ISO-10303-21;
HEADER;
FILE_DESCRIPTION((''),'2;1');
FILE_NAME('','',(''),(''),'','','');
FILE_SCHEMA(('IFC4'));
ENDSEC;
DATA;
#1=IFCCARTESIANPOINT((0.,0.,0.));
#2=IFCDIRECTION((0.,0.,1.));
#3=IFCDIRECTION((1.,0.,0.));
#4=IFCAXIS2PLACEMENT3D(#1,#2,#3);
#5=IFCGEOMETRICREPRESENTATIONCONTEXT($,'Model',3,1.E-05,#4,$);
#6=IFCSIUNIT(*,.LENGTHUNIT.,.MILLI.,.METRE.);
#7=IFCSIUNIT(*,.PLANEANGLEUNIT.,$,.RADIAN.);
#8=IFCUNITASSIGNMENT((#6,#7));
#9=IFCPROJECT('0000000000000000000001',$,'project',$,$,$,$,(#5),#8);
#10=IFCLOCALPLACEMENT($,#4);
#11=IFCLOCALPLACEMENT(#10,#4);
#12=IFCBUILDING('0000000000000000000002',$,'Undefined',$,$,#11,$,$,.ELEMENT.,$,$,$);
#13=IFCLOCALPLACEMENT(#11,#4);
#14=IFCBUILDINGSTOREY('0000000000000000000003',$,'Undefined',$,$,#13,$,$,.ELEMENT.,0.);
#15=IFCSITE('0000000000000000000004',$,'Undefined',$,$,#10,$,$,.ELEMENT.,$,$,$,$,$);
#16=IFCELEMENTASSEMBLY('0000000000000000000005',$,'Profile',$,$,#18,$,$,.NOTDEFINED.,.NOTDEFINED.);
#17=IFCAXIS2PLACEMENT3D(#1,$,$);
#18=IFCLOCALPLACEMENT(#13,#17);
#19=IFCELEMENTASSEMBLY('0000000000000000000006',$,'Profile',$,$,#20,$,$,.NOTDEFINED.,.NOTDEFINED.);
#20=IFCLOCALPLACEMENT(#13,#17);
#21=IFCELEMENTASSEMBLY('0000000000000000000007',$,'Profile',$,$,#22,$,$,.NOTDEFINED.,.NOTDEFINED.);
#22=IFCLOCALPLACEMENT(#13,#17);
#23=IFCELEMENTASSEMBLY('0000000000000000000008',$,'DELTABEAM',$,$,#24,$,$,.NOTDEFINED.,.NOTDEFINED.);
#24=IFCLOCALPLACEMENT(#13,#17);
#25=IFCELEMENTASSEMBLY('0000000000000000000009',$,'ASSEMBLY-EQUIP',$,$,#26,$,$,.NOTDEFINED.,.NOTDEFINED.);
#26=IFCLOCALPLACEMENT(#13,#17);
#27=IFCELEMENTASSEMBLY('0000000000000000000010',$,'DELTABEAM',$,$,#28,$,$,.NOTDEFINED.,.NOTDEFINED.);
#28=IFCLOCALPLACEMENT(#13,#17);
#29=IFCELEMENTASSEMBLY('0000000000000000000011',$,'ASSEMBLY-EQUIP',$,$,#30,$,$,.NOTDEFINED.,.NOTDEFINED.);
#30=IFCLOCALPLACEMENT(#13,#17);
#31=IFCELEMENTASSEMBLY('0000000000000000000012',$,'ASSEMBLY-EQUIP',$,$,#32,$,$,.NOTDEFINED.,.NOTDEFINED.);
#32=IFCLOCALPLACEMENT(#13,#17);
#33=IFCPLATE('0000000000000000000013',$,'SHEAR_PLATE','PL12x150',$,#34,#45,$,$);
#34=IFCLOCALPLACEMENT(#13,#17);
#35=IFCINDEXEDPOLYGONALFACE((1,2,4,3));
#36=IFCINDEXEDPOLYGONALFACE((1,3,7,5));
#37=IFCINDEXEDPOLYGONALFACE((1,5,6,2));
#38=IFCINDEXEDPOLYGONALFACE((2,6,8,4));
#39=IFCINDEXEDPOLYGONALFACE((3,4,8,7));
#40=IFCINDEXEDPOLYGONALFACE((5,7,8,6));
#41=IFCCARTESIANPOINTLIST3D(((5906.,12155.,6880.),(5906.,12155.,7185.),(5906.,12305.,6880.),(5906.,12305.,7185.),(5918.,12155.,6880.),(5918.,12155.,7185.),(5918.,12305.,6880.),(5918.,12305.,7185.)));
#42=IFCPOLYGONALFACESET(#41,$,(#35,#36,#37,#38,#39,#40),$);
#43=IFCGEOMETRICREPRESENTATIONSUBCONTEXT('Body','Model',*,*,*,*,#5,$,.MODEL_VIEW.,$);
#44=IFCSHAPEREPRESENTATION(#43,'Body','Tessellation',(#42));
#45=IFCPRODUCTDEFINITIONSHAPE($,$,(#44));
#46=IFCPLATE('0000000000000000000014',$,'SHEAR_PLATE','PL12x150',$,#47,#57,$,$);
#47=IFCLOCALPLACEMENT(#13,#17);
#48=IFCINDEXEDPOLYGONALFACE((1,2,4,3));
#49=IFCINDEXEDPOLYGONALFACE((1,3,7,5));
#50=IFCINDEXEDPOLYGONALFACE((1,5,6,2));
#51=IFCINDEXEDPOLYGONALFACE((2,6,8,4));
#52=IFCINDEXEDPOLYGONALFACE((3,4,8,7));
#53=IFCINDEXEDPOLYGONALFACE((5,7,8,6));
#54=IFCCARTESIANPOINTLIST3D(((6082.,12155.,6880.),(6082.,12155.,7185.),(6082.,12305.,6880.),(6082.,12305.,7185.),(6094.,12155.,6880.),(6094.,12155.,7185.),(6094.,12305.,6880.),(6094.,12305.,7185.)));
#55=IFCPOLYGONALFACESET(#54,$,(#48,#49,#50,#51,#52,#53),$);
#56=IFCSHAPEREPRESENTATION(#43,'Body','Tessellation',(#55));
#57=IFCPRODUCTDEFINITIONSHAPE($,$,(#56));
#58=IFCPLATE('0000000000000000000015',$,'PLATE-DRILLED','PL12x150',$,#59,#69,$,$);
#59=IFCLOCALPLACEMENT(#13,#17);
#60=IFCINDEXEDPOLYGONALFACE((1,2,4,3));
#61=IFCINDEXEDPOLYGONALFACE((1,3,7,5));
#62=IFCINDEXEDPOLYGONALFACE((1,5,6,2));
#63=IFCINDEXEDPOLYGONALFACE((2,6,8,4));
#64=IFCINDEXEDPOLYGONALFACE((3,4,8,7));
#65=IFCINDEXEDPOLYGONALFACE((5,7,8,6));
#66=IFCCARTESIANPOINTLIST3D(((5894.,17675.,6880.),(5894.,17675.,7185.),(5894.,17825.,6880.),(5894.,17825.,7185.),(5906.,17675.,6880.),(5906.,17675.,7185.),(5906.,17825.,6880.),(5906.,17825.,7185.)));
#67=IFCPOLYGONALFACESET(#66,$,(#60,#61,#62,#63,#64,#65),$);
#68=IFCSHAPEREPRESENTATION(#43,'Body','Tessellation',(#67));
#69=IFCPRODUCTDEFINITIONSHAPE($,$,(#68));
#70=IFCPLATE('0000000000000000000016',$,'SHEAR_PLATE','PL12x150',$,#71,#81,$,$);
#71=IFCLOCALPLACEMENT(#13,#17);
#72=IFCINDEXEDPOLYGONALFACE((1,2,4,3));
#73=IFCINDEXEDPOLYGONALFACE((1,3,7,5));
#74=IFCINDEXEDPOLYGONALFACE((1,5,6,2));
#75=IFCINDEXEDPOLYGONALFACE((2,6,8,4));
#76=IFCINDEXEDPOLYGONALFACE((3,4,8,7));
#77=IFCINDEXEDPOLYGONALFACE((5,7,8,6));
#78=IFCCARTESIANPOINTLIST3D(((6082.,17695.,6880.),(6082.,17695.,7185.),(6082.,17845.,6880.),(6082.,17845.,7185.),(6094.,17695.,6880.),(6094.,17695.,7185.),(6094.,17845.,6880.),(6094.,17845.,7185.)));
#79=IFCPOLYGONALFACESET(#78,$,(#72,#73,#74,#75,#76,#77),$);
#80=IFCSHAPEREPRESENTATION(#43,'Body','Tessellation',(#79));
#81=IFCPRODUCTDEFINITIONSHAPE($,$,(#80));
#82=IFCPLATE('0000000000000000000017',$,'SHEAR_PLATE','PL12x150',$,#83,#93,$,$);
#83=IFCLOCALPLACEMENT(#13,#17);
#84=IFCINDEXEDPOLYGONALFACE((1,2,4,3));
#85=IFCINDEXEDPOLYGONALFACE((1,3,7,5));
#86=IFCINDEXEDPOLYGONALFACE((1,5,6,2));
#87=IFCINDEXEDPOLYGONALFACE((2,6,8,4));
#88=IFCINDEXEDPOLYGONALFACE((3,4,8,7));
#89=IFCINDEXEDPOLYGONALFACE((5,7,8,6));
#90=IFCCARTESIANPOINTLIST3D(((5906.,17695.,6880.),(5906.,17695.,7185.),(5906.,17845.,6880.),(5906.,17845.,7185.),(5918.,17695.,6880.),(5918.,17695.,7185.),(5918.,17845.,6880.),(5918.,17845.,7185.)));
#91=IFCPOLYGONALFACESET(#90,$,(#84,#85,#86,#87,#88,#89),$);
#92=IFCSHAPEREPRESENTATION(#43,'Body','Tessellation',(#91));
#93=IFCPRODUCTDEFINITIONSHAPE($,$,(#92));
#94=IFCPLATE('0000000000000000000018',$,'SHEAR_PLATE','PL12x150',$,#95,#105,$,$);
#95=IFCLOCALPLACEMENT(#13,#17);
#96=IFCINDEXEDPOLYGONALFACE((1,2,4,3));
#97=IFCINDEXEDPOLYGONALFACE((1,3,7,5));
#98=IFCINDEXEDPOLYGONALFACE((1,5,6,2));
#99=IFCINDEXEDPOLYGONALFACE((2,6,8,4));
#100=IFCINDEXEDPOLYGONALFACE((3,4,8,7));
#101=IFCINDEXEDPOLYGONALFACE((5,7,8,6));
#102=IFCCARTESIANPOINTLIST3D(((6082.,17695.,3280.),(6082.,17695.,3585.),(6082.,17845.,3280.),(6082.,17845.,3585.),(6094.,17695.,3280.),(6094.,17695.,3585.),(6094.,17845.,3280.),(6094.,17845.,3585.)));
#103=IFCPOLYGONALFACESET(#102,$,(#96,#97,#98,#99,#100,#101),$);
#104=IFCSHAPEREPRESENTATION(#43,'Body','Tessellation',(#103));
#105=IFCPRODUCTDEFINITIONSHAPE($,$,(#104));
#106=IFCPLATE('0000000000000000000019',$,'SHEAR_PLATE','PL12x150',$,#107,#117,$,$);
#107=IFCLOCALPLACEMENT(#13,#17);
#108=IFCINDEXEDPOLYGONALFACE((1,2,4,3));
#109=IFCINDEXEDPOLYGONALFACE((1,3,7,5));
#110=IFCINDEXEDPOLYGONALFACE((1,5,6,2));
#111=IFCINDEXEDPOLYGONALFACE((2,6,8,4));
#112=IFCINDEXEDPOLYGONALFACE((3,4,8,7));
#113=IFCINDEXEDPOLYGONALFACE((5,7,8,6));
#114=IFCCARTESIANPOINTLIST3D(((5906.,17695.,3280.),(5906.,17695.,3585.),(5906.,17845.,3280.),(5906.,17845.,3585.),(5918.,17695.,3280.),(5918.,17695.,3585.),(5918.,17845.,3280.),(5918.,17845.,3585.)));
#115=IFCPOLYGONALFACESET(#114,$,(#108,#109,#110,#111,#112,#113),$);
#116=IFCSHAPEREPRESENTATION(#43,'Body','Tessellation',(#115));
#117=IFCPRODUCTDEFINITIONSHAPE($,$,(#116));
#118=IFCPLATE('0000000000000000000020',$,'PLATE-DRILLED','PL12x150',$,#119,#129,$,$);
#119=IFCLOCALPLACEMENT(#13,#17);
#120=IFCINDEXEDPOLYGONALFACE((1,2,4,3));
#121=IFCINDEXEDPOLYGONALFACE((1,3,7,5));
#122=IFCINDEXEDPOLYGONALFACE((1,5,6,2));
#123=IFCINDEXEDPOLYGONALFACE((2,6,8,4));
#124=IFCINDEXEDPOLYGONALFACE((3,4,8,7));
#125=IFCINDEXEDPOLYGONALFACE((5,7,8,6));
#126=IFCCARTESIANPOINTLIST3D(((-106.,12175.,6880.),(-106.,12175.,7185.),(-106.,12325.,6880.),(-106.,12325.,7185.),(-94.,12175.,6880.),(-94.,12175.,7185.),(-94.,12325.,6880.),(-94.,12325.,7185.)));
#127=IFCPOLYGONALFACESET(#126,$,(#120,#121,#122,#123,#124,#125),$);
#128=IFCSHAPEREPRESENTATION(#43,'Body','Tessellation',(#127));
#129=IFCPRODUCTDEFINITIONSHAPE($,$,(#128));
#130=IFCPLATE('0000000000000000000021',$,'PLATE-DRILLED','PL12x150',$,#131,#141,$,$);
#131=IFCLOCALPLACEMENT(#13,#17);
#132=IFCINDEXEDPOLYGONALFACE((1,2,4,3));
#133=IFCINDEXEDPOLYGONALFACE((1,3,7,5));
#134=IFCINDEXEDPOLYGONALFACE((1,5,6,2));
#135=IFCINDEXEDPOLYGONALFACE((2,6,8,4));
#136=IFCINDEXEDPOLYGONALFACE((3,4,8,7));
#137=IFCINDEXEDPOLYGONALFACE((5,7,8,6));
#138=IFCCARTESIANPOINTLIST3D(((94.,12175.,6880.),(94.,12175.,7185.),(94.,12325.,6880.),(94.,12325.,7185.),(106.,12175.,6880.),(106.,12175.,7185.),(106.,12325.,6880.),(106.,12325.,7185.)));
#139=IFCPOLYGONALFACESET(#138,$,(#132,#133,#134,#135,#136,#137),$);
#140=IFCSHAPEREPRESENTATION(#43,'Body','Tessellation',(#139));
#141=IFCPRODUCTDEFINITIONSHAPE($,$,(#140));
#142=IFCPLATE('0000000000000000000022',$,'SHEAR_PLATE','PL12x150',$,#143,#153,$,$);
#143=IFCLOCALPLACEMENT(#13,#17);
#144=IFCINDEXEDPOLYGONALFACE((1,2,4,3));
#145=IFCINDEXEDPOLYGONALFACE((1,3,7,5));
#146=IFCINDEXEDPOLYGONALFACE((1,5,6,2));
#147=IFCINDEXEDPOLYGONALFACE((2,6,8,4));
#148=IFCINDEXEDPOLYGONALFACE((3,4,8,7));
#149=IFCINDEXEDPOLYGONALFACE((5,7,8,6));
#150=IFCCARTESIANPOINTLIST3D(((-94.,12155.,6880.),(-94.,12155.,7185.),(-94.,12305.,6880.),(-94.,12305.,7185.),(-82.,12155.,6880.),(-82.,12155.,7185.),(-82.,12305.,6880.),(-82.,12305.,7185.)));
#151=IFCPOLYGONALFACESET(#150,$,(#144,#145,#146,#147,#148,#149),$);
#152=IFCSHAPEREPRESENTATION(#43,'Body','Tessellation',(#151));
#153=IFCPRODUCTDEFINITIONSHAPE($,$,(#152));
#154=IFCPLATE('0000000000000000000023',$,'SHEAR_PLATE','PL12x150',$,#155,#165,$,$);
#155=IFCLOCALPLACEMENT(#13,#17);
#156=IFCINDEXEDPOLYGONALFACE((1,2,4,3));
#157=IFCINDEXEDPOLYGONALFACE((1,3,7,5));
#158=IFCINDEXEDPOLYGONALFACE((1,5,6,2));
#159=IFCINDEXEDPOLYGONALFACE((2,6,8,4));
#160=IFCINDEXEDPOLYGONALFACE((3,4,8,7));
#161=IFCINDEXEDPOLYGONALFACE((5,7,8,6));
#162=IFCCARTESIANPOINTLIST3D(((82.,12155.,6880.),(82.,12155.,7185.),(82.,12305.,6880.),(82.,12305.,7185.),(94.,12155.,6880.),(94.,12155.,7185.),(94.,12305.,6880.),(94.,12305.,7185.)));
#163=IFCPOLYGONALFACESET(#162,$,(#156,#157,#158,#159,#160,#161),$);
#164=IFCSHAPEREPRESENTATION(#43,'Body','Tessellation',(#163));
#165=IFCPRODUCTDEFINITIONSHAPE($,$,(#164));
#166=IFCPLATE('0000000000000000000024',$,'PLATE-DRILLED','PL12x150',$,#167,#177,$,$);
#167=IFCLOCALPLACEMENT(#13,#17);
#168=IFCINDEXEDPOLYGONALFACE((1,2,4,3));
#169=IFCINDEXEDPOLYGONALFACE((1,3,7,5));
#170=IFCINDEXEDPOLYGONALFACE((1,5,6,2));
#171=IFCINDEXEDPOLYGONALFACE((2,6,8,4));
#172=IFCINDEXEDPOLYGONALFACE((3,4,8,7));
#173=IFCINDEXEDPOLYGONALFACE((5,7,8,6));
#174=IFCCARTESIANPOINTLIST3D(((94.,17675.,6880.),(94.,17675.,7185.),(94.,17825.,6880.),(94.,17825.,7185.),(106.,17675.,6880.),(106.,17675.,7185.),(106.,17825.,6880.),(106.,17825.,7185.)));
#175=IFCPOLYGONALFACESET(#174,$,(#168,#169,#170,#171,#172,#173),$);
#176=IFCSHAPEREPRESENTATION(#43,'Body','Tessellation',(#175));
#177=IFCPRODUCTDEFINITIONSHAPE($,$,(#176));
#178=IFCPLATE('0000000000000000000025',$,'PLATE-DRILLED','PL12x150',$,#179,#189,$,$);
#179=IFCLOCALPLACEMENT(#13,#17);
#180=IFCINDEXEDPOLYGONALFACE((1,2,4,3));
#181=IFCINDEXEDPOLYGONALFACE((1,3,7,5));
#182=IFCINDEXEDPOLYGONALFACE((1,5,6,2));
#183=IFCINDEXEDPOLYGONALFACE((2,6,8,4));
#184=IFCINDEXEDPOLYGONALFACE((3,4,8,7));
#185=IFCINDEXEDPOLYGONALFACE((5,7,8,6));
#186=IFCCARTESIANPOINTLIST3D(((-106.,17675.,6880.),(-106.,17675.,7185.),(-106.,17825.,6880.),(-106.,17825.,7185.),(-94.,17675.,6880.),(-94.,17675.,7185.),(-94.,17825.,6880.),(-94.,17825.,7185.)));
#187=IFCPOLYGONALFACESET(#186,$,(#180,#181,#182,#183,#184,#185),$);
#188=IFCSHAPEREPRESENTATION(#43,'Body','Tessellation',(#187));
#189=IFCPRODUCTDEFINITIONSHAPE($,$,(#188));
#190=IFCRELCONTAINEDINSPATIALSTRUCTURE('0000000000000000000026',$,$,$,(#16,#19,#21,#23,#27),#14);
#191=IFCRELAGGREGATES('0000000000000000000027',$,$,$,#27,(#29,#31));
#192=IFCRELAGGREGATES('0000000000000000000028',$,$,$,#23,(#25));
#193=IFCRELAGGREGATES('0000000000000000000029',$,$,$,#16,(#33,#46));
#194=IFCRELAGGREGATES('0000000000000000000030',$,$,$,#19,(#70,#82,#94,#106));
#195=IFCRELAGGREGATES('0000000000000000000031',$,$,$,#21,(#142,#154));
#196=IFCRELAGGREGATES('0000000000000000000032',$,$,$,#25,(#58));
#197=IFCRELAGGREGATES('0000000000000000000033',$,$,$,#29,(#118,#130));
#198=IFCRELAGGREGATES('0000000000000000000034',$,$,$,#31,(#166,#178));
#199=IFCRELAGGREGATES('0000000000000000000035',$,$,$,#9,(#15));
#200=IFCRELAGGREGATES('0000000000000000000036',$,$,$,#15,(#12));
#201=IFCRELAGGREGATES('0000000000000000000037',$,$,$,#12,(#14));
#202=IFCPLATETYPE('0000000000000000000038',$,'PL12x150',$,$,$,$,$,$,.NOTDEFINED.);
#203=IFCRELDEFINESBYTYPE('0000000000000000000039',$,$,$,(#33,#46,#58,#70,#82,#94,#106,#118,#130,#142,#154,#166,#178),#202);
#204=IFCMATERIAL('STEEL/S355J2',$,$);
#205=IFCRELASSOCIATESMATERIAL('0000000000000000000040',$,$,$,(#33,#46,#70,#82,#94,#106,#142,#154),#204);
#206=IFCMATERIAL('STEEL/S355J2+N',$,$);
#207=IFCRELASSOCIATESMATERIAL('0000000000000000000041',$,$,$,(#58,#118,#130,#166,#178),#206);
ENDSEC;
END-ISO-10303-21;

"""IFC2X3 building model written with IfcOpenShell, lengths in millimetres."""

from ifc_helpers import new_model, si_unit, frame, origin_with_axes, place, context, subcontext, project, spatial, polyline, outline, extrude, material, type_object, element, aggregate, save


model = new_model("IFC2X3")

# Units and contexts
model_context = context("Model", 3, precision=1e-05, world=origin_with_axes())
body_context = subcontext(model_context, "Body", "Model", "MODEL_VIEW")
ifc_project = project(units=[si_unit("LENGTHUNIT", "METRE", prefix="MILLI"), si_unit("PLANEANGLEUNIT", "RADIAN")], contexts=[model_context])

# Site, building, storey
site_placement = place(None, origin_with_axes())
site = spatial("IfcSite", under=ifc_project, at=site_placement, Name="Undefined", CompositionType="ELEMENT")
building_placement = place(site_placement, origin_with_axes())
building = spatial("IfcBuilding", under=site, at=building_placement, Name="Undefined", CompositionType="ELEMENT")
storey_placement = place(building_placement, origin_with_axes())
storey = spatial("IfcBuildingStorey", under=building, at=storey_placement, Name="Undefined", CompositionType="ELEMENT", Elevation=0.0)

# Element assemblies
assembly_1_placement = place(storey_placement, origin_with_axes())
assembly_1 = element("IfcElementAssembly", 1, at=assembly_1_placement, inside=storey, Name="Profile", AssemblyPlace="NOTDEFINED", PredefinedType="NOTDEFINED")
ifc_material_1 = material(Name="STEEL/S355J2")
assembly_2_placement = place(storey_placement, origin_with_axes())
assembly_2 = element("IfcElementAssembly", 2, at=assembly_2_placement, inside=storey, Name="Profile", AssemblyPlace="NOTDEFINED", PredefinedType="NOTDEFINED")
assembly_3_placement = place(storey_placement, origin_with_axes())
assembly_3 = element("IfcElementAssembly", 3, at=assembly_3_placement, inside=storey, Name="Profile", AssemblyPlace="NOTDEFINED", PredefinedType="NOTDEFINED")

# Element assemblies
assembly_4_placement = place(storey_placement, origin_with_axes())
assembly_4 = element("IfcElementAssembly", 4, at=assembly_4_placement, inside=storey, Name="DELTABEAM", AssemblyPlace="NOTDEFINED", PredefinedType="NOTDEFINED")
assembly_5_placement = place(assembly_4_placement, origin_with_axes())
assembly_5 = element("IfcElementAssembly", 5, at=assembly_5_placement, Name="ASSEMBLY-EQUIP", AssemblyPlace="NOTDEFINED", PredefinedType="NOTDEFINED")
ifc_material_2 = material(Name="STEEL/S355J2+N")

# Element assemblies
assembly_6_placement = place(storey_placement, origin_with_axes())
assembly_6 = element("IfcElementAssembly", 6, at=assembly_6_placement, inside=storey, Name="DELTABEAM", AssemblyPlace="NOTDEFINED", PredefinedType="NOTDEFINED")
assembly_7_placement = place(assembly_6_placement, origin_with_axes())
assembly_7 = element("IfcElementAssembly", 7, at=assembly_7_placement, Name="ASSEMBLY-EQUIP", AssemblyPlace="NOTDEFINED", PredefinedType="NOTDEFINED")
assembly_8_placement = place(assembly_6_placement, origin_with_axes())
assembly_8 = element("IfcElementAssembly", 8, at=assembly_8_placement, Name="ASSEMBLY-EQUIP", AssemblyPlace="NOTDEFINED", PredefinedType="NOTDEFINED")
aggregate(assembly_6, [assembly_7, assembly_8])

aggregate(assembly_4, [assembly_5])

# Plates
plate_type_1 = type_object("IfcPlateType", Name="PL12x150", PredefinedType="NOTDEFINED")
plate_1_placement = place(assembly_1_placement, frame((5912.0, 12155.0, 7185.0), z_axis=(-1.0, 0.0, 0.0), x_axis=(0.0, 1.0, 0.0)))
plate_1 = element("IfcPlate", 9, at=plate_1_placement, type_object=plate_type_1, material=ifc_material_1, Name="SHEAR_PLATE", Description="PL12x150", context=body_context, shape_type="SweptSolid", body=[
    extrude(outline(polyline([(0.0, 0.0), (150.0, 0.0), (150.0, 0.0), (150.0, 305.0), (150.0, 305.0), (0.0, 305.0), (0.0, 305.0), (0.0, 0.0)])), frame((0.0, 0.0, -6.0), z_axis=(0.0, 0.0, 1.0), x_axis=(1.0, 0.0, 0.0)), (0.0, 0.0, 1.0), 12.0),
])
plate_2_placement = place(assembly_1_placement, frame((6088.0, 12155.0, 7185.0), z_axis=(-1.0, 0.0, 0.0), x_axis=(0.0, 1.0, 0.0)))
plate_2 = element("IfcPlate", 10, at=plate_2_placement, type_object=plate_type_1, material=ifc_material_1, Name="SHEAR_PLATE", Description="PL12x150", context=body_context, shape_type="SweptSolid", body=[
    extrude(outline(polyline([(0.0, 0.0), (150.0, 0.0), (150.0, 0.0), (150.0, 305.0), (150.0, 305.0), (0.0, 305.0), (0.0, 305.0), (0.0, 0.0)])), frame((0.0, 0.0, -6.0), z_axis=(0.0, 0.0, 1.0), x_axis=(1.0, 0.0, 0.0)), (0.0, 0.0, 1.0), 12.0),
])
aggregate(assembly_1, [plate_1, plate_2])
plate_3_placement = place(assembly_5_placement, frame((5900.0, 17675.0, 7185.0), z_axis=(-1.0, 0.0, 0.0), x_axis=(0.0, 1.0, 0.0)))
plate_3 = element("IfcPlate", 11, at=plate_3_placement, type_object=plate_type_1, material=ifc_material_2, Name="PLATE-DRILLED", Description="PL12x150", context=body_context, shape_type="SweptSolid", body=[
    extrude(outline(polyline([(0.0, 0.0), (150.0, 0.0), (150.0, 0.0), (150.0, 305.0), (150.0, 305.0), (0.0, 305.0), (0.0, 305.0), (0.0, 0.0)])), frame((0.0, 0.0, -6.0), z_axis=(0.0, 0.0, 1.0), x_axis=(1.0, 0.0, 0.0)), (0.0, 0.0, 1.0), 12.0),
])
plate_4_placement = place(assembly_2_placement, frame((6088.0, 17845.0, 7185.0), z_axis=(1.0, 0.0, 0.0), x_axis=(0.0, -1.0, 0.0)))
plate_4 = element("IfcPlate", 12, at=plate_4_placement, type_object=plate_type_1, material=ifc_material_1, Name="SHEAR_PLATE", Description="PL12x150", context=body_context, shape_type="SweptSolid", body=[
    extrude(outline(polyline([(0.0, 0.0), (150.0, 0.0), (150.0, 0.0), (150.0, 305.0), (150.0, 305.0), (0.0, 305.0), (0.0, 305.0), (0.0, 0.0)])), frame((0.0, 0.0, -6.0), z_axis=(0.0, 0.0, 1.0), x_axis=(1.0, 0.0, 0.0)), (0.0, 0.0, 1.0), 12.0),
])
plate_5_placement = place(assembly_2_placement, frame((5912.0, 17845.0, 7185.0), z_axis=(1.0, 0.0, 0.0), x_axis=(0.0, -1.0, 0.0)))
plate_5 = element("IfcPlate", 13, at=plate_5_placement, type_object=plate_type_1, material=ifc_material_1, Name="SHEAR_PLATE", Description="PL12x150", context=body_context, shape_type="SweptSolid", body=[
    extrude(outline(polyline([(0.0, 0.0), (150.0, 0.0), (150.0, 0.0), (150.0, 305.0), (150.0, 305.0), (0.0, 305.0), (0.0, 305.0), (0.0, 0.0)])), frame((0.0, 0.0, -6.0), z_axis=(0.0, 0.0, 1.0), x_axis=(1.0, 0.0, 0.0)), (0.0, 0.0, 1.0), 12.0),
])
plate_6_placement = place(assembly_2_placement, frame((6088.0, 17845.0, 3585.0), z_axis=(1.0, 0.0, 0.0), x_axis=(0.0, -1.0, 0.0)))
plate_6 = element("IfcPlate", 14, at=plate_6_placement, type_object=plate_type_1, material=ifc_material_1, Name="SHEAR_PLATE", Description="PL12x150", context=body_context, shape_type="SweptSolid", body=[
    extrude(outline(polyline([(0.0, 0.0), (150.0, 0.0), (150.0, 0.0), (150.0, 305.0), (150.0, 305.0), (0.0, 305.0), (0.0, 305.0), (0.0, 0.0)])), frame((0.0, 0.0, -6.0), z_axis=(0.0, 0.0, 1.0), x_axis=(1.0, 0.0, 0.0)), (0.0, 0.0, 1.0), 12.0),
])
plate_7_placement = place(assembly_2_placement, frame((5912.0, 17845.0, 3585.0), z_axis=(1.0, 0.0, 0.0), x_axis=(0.0, -1.0, 0.0)))
plate_7 = element("IfcPlate", 15, at=plate_7_placement, type_object=plate_type_1, material=ifc_material_1, Name="SHEAR_PLATE", Description="PL12x150", context=body_context, shape_type="SweptSolid", body=[
    extrude(outline(polyline([(0.0, 0.0), (150.0, 0.0), (150.0, 0.0), (150.0, 305.0), (150.0, 305.0), (0.0, 305.0), (0.0, 305.0), (0.0, 0.0)])), frame((0.0, 0.0, -6.0), z_axis=(0.0, 0.0, 1.0), x_axis=(1.0, 0.0, 0.0)), (0.0, 0.0, 1.0), 12.0),
])
aggregate(assembly_2, [plate_4, plate_5, plate_6, plate_7])
plate_8_placement = place(assembly_7_placement, frame((-100.0, 12325.0, 7185.0), z_axis=(1.0, 0.0, 0.0), x_axis=(0.0, -1.0, 0.0)))
plate_8 = element("IfcPlate", 16, at=plate_8_placement, type_object=plate_type_1, material=ifc_material_2, Name="PLATE-DRILLED", Description="PL12x150", context=body_context, shape_type="SweptSolid", body=[
    extrude(outline(polyline([(0.0, 0.0), (150.0, 0.0), (150.0, 0.0), (150.0, 305.0), (150.0, 305.0), (0.0, 305.0), (0.0, 305.0), (0.0, 0.0)])), frame((0.0, 0.0, -6.0), z_axis=(0.0, 0.0, 1.0), x_axis=(1.0, 0.0, 0.0)), (0.0, 0.0, 1.0), 12.0),
])
plate_9_placement = place(assembly_7_placement, frame((100.0, 12325.0, 7185.0), z_axis=(1.0, 0.0, 0.0), x_axis=(0.0, -1.0, 0.0)))
plate_9 = element("IfcPlate", 17, at=plate_9_placement, type_object=plate_type_1, material=ifc_material_2, Name="PLATE-DRILLED", Description="PL12x150", context=body_context, shape_type="SweptSolid", body=[
    extrude(outline(polyline([(0.0, 0.0), (150.0, 0.0), (150.0, 0.0), (150.0, 305.0), (150.0, 305.0), (0.0, 305.0), (0.0, 305.0), (0.0, 0.0)])), frame((0.0, 0.0, -6.0), z_axis=(0.0, 0.0, 1.0), x_axis=(1.0, 0.0, 0.0)), (0.0, 0.0, 1.0), 12.0),
])
plate_10_placement = place(assembly_3_placement, frame((-88.0, 12155.0, 7185.0), z_axis=(-1.0, 0.0, 0.0), x_axis=(0.0, 1.0, 0.0)))
plate_10 = element("IfcPlate", 18, at=plate_10_placement, type_object=plate_type_1, material=ifc_material_1, Name="SHEAR_PLATE", Description="PL12x150", context=body_context, shape_type="SweptSolid", body=[
    extrude(outline(polyline([(0.0, 0.0), (150.0, 0.0), (150.0, 0.0), (150.0, 305.0), (150.0, 305.0), (0.0, 305.0), (0.0, 305.0), (0.0, 0.0)])), frame((0.0, 0.0, -6.0), z_axis=(0.0, 0.0, 1.0), x_axis=(1.0, 0.0, 0.0)), (0.0, 0.0, 1.0), 12.0),
])
plate_11_placement = place(assembly_3_placement, frame((88.0, 12155.0, 7185.0), z_axis=(-1.0, 0.0, 0.0), x_axis=(0.0, 1.0, 0.0)))
plate_11 = element("IfcPlate", 19, at=plate_11_placement, type_object=plate_type_1, material=ifc_material_1, Name="SHEAR_PLATE", Description="PL12x150", context=body_context, shape_type="SweptSolid", body=[
    extrude(outline(polyline([(0.0, 0.0), (150.0, 0.0), (150.0, 0.0), (150.0, 305.0), (150.0, 305.0), (0.0, 305.0), (0.0, 305.0), (0.0, 0.0)])), frame((0.0, 0.0, -6.0), z_axis=(0.0, 0.0, 1.0), x_axis=(1.0, 0.0, 0.0)), (0.0, 0.0, 1.0), 12.0),
])
aggregate(assembly_3, [plate_10, plate_11])
plate_12_placement = place(assembly_8_placement, frame((100.0, 17675.0, 7185.0), z_axis=(-1.0, 0.0, 0.0), x_axis=(0.0, 1.0, 0.0)))
plate_12 = element("IfcPlate", 20, at=plate_12_placement, type_object=plate_type_1, material=ifc_material_2, Name="PLATE-DRILLED", Description="PL12x150", context=body_context, shape_type="SweptSolid", body=[
    extrude(outline(polyline([(0.0, 0.0), (150.0, 0.0), (150.0, 0.0), (150.0, 305.0), (150.0, 305.0), (0.0, 305.0), (0.0, 305.0), (0.0, 0.0)])), frame((0.0, 0.0, -6.0), z_axis=(0.0, 0.0, 1.0), x_axis=(1.0, 0.0, 0.0)), (0.0, 0.0, 1.0), 12.0),
])
plate_13_placement = place(assembly_8_placement, frame((-100.0, 17675.0, 7185.0), z_axis=(-1.0, 0.0, 0.0), x_axis=(0.0, 1.0, 0.0)))
plate_13 = element("IfcPlate", 21, at=plate_13_placement, type_object=plate_type_1, material=ifc_material_2, Name="PLATE-DRILLED", Description="PL12x150", context=body_context, shape_type="SweptSolid", body=[
    extrude(outline(polyline([(0.0, 0.0), (150.0, 0.0), (150.0, 0.0), (150.0, 305.0), (150.0, 305.0), (0.0, 305.0), (0.0, 305.0), (0.0, 0.0)])), frame((0.0, 0.0, -6.0), z_axis=(0.0, 0.0, 1.0), x_axis=(1.0, 0.0, 0.0)), (0.0, 0.0, 1.0), 12.0),
])

aggregate(assembly_5, [plate_3])
aggregate(assembly_7, [plate_8, plate_9])
aggregate(assembly_8, [plate_12, plate_13])

save(model, "model.ifc")
